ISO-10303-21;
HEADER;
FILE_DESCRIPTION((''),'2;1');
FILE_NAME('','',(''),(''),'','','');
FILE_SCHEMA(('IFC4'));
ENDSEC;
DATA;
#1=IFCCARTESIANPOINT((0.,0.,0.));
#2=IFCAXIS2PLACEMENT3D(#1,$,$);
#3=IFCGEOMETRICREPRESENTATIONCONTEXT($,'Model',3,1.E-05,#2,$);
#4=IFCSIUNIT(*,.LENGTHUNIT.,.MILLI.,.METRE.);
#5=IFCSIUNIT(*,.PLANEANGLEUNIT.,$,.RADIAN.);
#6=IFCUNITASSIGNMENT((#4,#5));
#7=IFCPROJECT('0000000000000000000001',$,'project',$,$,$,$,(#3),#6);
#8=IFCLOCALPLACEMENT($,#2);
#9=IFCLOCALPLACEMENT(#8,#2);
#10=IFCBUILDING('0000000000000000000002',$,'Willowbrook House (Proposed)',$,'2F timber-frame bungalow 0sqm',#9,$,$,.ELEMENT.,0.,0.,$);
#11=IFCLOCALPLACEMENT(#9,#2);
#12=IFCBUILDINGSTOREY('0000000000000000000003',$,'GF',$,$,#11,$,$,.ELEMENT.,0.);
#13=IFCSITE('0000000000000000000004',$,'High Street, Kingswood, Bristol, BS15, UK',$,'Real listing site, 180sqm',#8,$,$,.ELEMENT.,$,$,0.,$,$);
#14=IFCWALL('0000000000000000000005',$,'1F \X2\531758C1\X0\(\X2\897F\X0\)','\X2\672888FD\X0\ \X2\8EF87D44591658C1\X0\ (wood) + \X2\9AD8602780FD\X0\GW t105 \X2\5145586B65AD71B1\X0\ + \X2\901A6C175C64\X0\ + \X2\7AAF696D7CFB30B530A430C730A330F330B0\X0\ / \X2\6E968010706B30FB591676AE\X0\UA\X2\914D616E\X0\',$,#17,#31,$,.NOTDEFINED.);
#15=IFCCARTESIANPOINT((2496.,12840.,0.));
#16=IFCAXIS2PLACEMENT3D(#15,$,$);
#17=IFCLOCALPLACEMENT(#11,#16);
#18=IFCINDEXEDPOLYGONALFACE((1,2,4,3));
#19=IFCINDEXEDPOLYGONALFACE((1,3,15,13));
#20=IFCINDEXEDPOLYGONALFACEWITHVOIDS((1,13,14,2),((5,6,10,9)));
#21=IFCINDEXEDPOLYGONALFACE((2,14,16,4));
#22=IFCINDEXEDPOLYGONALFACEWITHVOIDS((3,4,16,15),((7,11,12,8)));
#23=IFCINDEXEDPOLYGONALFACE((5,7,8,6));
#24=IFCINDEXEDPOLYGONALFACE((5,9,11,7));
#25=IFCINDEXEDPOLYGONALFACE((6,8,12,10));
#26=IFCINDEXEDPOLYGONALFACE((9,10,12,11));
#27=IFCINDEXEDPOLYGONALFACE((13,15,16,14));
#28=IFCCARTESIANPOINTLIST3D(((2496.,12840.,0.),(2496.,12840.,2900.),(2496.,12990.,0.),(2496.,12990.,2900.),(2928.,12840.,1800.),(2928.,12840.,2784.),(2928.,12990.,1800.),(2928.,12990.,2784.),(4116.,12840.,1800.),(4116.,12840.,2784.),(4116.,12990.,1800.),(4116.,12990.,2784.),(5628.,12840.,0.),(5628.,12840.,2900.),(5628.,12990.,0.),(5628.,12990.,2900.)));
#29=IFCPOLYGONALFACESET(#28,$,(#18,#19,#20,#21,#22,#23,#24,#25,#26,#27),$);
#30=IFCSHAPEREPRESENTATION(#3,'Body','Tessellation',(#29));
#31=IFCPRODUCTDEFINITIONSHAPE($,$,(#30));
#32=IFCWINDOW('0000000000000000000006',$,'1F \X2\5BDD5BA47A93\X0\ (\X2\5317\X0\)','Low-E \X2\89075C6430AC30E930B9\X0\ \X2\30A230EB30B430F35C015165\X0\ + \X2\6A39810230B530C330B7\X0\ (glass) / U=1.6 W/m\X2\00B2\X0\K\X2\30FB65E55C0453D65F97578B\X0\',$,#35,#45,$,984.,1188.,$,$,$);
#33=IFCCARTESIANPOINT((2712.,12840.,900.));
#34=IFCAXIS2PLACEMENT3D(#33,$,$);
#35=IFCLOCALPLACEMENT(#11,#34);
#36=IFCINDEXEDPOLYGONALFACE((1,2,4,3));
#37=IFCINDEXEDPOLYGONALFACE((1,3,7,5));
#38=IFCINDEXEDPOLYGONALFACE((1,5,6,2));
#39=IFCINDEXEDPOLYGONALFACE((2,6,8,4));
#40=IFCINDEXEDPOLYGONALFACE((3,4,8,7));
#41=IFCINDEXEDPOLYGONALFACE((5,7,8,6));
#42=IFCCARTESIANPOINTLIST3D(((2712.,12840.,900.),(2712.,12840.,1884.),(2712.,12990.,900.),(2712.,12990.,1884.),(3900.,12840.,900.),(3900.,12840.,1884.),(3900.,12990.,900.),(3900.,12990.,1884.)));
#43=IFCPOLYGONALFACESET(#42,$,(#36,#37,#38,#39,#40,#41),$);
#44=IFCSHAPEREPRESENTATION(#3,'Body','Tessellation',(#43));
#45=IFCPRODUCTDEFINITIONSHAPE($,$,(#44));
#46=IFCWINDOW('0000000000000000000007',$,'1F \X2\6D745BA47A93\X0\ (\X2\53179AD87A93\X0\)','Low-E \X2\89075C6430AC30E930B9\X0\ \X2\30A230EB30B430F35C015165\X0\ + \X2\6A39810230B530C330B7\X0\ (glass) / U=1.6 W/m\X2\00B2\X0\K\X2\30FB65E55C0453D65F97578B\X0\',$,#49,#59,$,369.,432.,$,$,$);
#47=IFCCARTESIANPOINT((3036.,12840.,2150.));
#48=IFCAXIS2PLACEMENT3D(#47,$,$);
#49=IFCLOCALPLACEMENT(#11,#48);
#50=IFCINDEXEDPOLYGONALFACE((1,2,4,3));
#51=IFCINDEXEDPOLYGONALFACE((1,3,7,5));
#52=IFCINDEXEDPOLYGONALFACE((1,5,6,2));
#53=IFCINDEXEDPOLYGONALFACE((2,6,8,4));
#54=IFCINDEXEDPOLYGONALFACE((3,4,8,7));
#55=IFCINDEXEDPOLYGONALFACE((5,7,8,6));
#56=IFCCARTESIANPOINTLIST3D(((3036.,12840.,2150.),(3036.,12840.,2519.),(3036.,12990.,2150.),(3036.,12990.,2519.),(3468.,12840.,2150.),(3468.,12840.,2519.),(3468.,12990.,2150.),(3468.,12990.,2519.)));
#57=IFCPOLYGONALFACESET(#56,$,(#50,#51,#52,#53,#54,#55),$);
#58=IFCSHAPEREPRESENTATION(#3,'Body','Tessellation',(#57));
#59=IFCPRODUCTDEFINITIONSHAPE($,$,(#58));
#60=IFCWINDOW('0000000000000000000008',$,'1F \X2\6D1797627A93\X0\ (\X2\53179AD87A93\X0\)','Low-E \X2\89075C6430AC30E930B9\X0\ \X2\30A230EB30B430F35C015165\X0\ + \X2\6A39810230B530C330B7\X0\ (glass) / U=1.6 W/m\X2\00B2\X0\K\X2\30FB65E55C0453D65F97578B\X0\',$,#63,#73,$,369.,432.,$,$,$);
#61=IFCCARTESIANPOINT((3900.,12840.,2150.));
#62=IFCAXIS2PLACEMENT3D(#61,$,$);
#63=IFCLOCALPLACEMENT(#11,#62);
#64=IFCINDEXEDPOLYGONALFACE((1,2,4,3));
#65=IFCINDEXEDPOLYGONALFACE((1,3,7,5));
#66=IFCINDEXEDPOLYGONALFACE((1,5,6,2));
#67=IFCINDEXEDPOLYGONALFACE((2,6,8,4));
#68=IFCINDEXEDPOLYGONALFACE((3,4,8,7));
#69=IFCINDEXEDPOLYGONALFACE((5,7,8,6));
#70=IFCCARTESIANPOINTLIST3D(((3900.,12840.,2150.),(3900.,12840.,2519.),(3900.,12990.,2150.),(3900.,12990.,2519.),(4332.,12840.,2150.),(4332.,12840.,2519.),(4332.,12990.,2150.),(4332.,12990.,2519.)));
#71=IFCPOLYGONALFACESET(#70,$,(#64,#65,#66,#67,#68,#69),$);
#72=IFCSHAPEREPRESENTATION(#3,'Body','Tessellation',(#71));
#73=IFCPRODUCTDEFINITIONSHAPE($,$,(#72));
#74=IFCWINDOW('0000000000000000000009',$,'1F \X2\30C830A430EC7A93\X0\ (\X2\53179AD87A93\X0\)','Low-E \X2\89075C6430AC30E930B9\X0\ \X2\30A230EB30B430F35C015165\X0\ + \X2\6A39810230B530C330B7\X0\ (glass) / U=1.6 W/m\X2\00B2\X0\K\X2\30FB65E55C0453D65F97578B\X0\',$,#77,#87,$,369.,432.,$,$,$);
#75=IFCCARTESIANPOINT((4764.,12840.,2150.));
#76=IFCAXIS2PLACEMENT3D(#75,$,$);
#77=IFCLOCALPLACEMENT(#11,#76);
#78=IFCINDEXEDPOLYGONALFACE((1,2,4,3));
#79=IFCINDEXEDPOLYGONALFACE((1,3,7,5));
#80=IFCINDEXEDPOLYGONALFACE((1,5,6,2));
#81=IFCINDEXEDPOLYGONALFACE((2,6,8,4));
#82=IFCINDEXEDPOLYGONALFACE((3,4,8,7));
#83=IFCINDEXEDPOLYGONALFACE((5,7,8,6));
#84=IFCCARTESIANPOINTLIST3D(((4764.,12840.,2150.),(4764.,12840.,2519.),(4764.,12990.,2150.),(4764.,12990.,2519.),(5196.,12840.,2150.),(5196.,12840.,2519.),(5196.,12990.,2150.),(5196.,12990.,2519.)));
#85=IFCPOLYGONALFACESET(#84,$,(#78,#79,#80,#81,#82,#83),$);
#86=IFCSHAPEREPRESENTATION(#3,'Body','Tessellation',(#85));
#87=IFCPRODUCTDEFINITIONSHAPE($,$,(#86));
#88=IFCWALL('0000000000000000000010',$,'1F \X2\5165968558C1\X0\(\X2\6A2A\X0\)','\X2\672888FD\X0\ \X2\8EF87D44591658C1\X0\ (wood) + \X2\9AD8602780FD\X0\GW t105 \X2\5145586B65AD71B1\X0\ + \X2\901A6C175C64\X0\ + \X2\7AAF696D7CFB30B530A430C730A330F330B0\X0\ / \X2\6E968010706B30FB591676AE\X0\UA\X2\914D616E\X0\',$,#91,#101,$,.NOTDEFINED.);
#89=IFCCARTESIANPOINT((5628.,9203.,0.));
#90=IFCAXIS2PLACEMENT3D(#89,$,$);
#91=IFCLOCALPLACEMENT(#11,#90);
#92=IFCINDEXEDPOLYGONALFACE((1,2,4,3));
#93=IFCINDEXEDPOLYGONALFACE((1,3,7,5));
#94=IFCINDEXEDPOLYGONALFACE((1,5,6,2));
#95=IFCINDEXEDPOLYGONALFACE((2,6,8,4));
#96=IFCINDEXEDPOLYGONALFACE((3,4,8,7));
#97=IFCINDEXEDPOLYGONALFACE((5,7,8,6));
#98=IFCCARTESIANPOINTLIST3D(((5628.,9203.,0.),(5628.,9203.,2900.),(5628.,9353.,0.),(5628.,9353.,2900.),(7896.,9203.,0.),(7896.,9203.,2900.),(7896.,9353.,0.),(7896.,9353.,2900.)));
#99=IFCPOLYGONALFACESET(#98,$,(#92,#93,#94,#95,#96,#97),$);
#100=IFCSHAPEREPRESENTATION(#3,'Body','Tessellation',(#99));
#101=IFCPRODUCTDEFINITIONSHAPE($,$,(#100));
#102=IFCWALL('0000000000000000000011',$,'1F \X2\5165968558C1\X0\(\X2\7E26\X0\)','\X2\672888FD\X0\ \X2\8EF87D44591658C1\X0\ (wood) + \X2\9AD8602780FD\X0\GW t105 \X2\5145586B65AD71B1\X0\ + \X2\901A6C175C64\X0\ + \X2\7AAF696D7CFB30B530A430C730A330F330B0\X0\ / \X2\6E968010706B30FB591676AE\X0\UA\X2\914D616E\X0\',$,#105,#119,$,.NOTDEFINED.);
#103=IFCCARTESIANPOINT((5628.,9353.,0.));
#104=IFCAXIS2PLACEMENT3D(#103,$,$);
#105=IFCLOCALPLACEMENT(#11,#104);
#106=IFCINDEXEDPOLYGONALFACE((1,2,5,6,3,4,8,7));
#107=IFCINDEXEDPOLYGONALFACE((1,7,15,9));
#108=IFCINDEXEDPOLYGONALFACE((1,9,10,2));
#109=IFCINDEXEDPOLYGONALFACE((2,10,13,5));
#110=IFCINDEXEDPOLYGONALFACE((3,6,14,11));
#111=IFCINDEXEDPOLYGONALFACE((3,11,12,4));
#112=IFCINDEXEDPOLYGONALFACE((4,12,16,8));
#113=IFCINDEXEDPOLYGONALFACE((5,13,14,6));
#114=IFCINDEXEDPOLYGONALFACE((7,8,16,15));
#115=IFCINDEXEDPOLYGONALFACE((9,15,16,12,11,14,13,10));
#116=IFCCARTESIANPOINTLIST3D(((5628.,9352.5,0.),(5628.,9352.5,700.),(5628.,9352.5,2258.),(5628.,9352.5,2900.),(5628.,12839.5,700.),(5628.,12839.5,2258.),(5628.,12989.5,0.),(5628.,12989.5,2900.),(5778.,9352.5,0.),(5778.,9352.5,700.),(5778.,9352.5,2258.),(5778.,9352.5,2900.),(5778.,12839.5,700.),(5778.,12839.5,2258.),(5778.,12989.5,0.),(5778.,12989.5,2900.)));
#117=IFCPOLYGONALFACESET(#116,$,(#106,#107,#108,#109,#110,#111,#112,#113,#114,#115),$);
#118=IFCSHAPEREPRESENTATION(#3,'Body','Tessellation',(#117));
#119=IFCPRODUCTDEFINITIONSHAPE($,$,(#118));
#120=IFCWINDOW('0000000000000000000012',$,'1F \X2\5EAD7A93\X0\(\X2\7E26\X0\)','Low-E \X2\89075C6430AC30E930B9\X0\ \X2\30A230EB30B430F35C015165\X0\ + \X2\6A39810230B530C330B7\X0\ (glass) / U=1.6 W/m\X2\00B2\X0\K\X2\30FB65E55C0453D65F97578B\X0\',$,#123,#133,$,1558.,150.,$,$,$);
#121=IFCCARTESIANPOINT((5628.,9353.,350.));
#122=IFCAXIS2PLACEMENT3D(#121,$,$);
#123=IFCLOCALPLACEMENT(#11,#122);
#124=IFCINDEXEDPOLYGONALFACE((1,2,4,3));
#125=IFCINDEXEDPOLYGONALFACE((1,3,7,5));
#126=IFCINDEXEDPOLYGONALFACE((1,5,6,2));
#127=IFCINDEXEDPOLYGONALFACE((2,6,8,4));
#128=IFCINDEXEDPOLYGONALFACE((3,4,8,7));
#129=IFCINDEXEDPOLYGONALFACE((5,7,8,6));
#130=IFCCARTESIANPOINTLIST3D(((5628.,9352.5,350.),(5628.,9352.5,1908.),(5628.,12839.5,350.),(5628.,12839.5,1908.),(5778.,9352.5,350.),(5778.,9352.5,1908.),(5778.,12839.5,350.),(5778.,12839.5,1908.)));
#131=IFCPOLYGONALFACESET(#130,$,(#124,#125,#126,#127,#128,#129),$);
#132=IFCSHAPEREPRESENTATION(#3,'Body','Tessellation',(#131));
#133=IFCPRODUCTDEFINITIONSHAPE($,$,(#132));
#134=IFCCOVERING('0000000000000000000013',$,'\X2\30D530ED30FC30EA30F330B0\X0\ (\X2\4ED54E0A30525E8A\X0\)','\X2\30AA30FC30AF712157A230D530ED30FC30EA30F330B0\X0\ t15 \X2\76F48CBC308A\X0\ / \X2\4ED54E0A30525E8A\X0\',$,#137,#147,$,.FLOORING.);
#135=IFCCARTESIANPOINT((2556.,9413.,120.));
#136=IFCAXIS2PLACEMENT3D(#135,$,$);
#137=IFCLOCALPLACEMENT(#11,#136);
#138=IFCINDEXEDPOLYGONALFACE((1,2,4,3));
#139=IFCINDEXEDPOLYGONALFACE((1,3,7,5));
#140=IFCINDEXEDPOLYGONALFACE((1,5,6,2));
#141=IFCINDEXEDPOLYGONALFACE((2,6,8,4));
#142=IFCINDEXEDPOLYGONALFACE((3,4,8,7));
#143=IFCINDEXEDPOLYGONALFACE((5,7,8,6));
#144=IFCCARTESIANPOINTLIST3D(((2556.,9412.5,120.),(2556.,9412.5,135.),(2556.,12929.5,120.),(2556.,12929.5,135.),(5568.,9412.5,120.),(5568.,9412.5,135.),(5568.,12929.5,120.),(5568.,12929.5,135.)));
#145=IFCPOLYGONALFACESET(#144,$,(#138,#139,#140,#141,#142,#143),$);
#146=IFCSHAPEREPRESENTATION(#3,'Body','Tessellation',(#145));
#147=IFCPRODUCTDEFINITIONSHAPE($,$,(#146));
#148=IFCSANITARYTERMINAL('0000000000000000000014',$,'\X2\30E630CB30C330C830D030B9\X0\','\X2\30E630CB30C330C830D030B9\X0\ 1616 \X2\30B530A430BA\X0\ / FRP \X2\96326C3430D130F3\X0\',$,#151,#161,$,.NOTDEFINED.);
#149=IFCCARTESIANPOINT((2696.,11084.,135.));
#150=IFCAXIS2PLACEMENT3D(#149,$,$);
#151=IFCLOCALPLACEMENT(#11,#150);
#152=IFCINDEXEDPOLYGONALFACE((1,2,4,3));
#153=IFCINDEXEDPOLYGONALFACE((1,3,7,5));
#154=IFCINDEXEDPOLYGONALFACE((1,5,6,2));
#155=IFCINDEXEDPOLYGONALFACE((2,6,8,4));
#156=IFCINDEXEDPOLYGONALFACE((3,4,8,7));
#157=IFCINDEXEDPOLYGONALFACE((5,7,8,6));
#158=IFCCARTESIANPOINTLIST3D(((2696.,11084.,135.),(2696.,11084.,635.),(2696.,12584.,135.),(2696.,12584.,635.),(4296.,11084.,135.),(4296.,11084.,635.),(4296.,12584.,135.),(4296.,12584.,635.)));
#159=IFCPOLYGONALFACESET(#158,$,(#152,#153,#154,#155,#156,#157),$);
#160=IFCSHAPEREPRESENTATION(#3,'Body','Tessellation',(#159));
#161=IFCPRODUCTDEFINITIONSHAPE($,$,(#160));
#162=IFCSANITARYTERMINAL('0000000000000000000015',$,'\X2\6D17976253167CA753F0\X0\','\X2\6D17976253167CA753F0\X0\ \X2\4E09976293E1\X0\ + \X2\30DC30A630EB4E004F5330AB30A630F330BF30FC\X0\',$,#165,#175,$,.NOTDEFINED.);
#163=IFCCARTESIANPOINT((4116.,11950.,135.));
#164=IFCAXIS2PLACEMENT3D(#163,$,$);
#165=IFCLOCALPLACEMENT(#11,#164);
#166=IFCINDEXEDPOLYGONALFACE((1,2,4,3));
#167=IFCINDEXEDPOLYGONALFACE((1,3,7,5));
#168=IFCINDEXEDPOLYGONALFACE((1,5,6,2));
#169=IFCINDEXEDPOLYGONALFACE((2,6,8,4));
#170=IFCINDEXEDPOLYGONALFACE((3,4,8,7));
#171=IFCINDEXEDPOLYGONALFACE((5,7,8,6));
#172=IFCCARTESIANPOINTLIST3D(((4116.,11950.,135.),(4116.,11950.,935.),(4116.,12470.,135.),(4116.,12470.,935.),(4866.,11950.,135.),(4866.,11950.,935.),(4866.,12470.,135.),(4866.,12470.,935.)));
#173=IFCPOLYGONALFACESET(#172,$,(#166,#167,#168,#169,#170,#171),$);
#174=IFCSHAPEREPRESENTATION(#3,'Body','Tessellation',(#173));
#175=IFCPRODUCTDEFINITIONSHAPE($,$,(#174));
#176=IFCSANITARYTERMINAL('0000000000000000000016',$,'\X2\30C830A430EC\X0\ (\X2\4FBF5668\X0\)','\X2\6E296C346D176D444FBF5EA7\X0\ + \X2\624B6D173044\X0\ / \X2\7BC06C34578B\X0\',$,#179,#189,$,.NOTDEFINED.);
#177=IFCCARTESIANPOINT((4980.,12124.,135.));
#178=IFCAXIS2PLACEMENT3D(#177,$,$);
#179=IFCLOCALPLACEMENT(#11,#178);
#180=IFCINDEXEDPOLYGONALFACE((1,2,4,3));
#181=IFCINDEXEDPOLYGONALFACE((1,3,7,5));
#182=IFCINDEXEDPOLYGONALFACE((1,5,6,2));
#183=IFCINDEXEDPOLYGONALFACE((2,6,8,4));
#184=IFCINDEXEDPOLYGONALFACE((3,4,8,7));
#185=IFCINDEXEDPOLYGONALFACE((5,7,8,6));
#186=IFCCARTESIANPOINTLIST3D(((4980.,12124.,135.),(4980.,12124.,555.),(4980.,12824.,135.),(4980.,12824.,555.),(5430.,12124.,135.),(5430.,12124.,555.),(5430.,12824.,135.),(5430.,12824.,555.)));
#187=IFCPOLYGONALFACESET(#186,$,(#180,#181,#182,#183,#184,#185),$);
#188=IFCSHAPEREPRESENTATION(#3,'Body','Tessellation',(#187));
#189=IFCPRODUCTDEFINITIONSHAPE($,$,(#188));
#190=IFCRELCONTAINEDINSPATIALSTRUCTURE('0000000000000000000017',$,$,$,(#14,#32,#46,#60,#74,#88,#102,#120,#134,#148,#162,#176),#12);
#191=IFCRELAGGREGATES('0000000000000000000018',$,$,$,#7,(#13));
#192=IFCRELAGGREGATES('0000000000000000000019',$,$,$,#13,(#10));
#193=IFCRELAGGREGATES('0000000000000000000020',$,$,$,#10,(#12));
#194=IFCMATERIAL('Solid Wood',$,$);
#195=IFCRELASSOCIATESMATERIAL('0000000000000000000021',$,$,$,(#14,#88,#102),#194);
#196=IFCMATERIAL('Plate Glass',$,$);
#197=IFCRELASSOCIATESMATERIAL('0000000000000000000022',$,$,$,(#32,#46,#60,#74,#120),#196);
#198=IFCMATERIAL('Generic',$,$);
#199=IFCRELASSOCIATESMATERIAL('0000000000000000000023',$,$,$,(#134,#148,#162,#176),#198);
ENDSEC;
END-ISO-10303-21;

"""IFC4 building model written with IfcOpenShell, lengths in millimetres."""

from ifc_helpers import new_model, si_unit, frame, frame_2d, origin, place, context, project, spatial, rectangle, extrude, material, element, fill, save


model = new_model("IFC4")

# Units and contexts
model_context = context("Model", 3, precision=1e-05, world=origin())
ifc_project = project(units=[si_unit("LENGTHUNIT", "METRE", prefix="MILLI"), si_unit("PLANEANGLEUNIT", "RADIAN")], contexts=[model_context])

# Site, building, storey
site_placement = place(None, origin())
site = spatial("IfcSite", under=ifc_project, at=site_placement, Name="High Street, Kingswood, Bristol, BS15, UK", ObjectType="Real listing site, 180sqm", CompositionType="ELEMENT", RefElevation=0.0)
building_placement = place(site_placement, origin())
building = spatial("IfcBuilding", under=site, at=building_placement, Name="Willowbrook House (Proposed)", ObjectType="2F timber-frame bungalow 0sqm", CompositionType="ELEMENT", ElevationOfRefHeight=0.0, ElevationOfTerrain=0.0)
storey_placement = place(building_placement, origin())
storey = spatial("IfcBuildingStorey", under=building, at=storey_placement, Name="GF", CompositionType="ELEMENT", Elevation=0.0)

# Shared definitions
ifc_material_1 = material(Name="Solid Wood")

# Wall, openings, windows
wall_1_placement = place(storey_placement, frame((2496.0, 12840.0, 0.0)))
wall_1 = element("IfcWall", 1, at=wall_1_placement, inside=storey, material=ifc_material_1, Name="1F 北壁(西)", Description="木製 軸組外壁 (wood) + 高性能GW t105 充填断熱 + 通気層 + 窯業系サイディング / 準耐火・外皮UA配慮", PredefinedType="NOTDEFINED", context=model_context, shape_type="SweptSolid", body=[
    extrude(rectangle(XDim=3132.0, YDim=150.0, at=frame_2d((1566.0, 75.0))), frame((2496.0, 12840.0, 0.0)), (0.0, 0.0, 1.0), 2900.0),
])
opening_1_placement = place(storey_placement, frame((2712.0, 12840.0, 900.0)))
opening_1 = element("IfcOpeningElement", 2, at=opening_1_placement, cuts=wall_1, PredefinedType="NOTDEFINED", context=model_context, shape_type="SweptSolid", body=[
    extrude(rectangle(XDim=1188.0, YDim=150.0, at=frame_2d((594.0, 75.0))), frame((2712.0, 12840.0, 900.0)), (0.0, 0.0, 1.0), 984.0),
])
opening_2_placement = place(storey_placement, frame((3036.0, 12840.0, 2150.0)))
opening_2 = element("IfcOpeningElement", 3, at=opening_2_placement, cuts=wall_1, PredefinedType="NOTDEFINED", context=model_context, shape_type="SweptSolid", body=[
    extrude(rectangle(XDim=432.0, YDim=150.0, at=frame_2d((216.0, 75.0))), frame((3036.0, 12840.0, 2150.0)), (0.0, 0.0, 1.0), 369.0),
])
opening_3_placement = place(storey_placement, frame((3900.0, 12840.0, 2150.0)))
opening_3 = element("IfcOpeningElement", 4, at=opening_3_placement, cuts=wall_1, PredefinedType="NOTDEFINED", context=model_context, shape_type="SweptSolid", body=[
    extrude(rectangle(XDim=432.0, YDim=150.0, at=frame_2d((216.0, 75.0))), frame((3900.0, 12840.0, 2150.0)), (0.0, 0.0, 1.0), 369.0),
])
opening_4_placement = place(storey_placement, frame((4764.0, 12840.0, 2150.0)))
opening_4 = element("IfcOpeningElement", 5, at=opening_4_placement, cuts=wall_1, PredefinedType="NOTDEFINED", context=model_context, shape_type="SweptSolid", body=[
    extrude(rectangle(XDim=432.0, YDim=150.0, at=frame_2d((216.0, 75.0))), frame((4764.0, 12840.0, 2150.0)), (0.0, 0.0, 1.0), 369.0),
])
ifc_material_2 = material(Name="Plate Glass")
window_1_placement = place(storey_placement, frame((2712.0, 12840.0, 900.0)))
window_1 = element("IfcWindow", 6, at=window_1_placement, inside=storey, material=ifc_material_2, Name="1F 寝室窓 (北)", Description="Low-E 複層ガラス アルゴン封入 + 樹脂サッシ (glass) / U=1.6 W/m²K・日射取得型", OverallHeight=984.0, OverallWidth=1188.0, context=model_context, shape_type="SweptSolid", body=[
    extrude(rectangle(XDim=1188.0, YDim=150.0, at=frame_2d((594.0, 75.0))), frame((2712.0, 12840.0, 900.0)), (0.0, 0.0, 1.0), 984.0),
])
fill(opening_1, window_1)
window_2_placement = place(storey_placement, frame((3036.0, 12840.0, 2150.0)))
window_2 = element("IfcWindow", 7, at=window_2_placement, inside=storey, material=ifc_material_2, Name="1F 浴室窓 (北高窓)", Description="Low-E 複層ガラス アルゴン封入 + 樹脂サッシ (glass) / U=1.6 W/m²K・日射取得型", OverallHeight=369.0, OverallWidth=432.0, context=model_context, shape_type="SweptSolid", body=[
    extrude(rectangle(XDim=432.0, YDim=150.0, at=frame_2d((216.0, 75.0))), frame((3036.0, 12840.0, 2150.0)), (0.0, 0.0, 1.0), 369.0),
])
fill(opening_2, window_2)
window_3_placement = place(storey_placement, frame((3900.0, 12840.0, 2150.0)))
window_3 = element("IfcWindow", 8, at=window_3_placement, inside=storey, material=ifc_material_2, Name="1F 洗面窓 (北高窓)", Description="Low-E 複層ガラス アルゴン封入 + 樹脂サッシ (glass) / U=1.6 W/m²K・日射取得型", OverallHeight=369.0, OverallWidth=432.0, context=model_context, shape_type="SweptSolid", body=[
    extrude(rectangle(XDim=432.0, YDim=150.0, at=frame_2d((216.0, 75.0))), frame((3900.0, 12840.0, 2150.0)), (0.0, 0.0, 1.0), 369.0),
])
fill(opening_3, window_3)
window_4_placement = place(storey_placement, frame((4764.0, 12840.0, 2150.0)))
window_4 = element("IfcWindow", 9, at=window_4_placement, inside=storey, material=ifc_material_2, Name="1F トイレ窓 (北高窓)", Description="Low-E 複層ガラス アルゴン封入 + 樹脂サッシ (glass) / U=1.6 W/m²K・日射取得型", OverallHeight=369.0, OverallWidth=432.0, context=model_context, shape_type="SweptSolid", body=[
    extrude(rectangle(XDim=432.0, YDim=150.0, at=frame_2d((216.0, 75.0))), frame((4764.0, 12840.0, 2150.0)), (0.0, 0.0, 1.0), 369.0),
])
fill(opening_4, window_4)

# Wall
wall_2_placement = place(storey_placement, frame((5628.0, 9203.0, 0.0)))
element("IfcWall", 10, at=wall_2_placement, inside=storey, material=ifc_material_1, Name="1F 入隅壁(横)", Description="木製 軸組外壁 (wood) + 高性能GW t105 充填断熱 + 通気層 + 窯業系サイディング / 準耐火・外皮UA配慮", PredefinedType="NOTDEFINED", context=model_context, shape_type="SweptSolid", body=[
    extrude(rectangle(XDim=2268.0, YDim=150.0, at=frame_2d((1134.0, 75.0))), frame((5628.0, 9203.0, 0.0)), (0.0, 0.0, 1.0), 2900.0),
])

# Wall, opening, window
wall_3_placement = place(storey_placement, frame((5628.0, 9353.0, 0.0)))
wall_3 = element("IfcWall", 11, at=wall_3_placement, inside=storey, material=ifc_material_1, Name="1F 入隅壁(縦)", Description="木製 軸組外壁 (wood) + 高性能GW t105 充填断熱 + 通気層 + 窯業系サイディング / 準耐火・外皮UA配慮", PredefinedType="NOTDEFINED", context=model_context, shape_type="SweptSolid", body=[
    extrude(rectangle(XDim=150.0, YDim=3637.0, at=frame_2d((75.0, 1818.0))), frame((5628.0, 9353.0, 0.0)), (0.0, 0.0, 1.0), 2900.0),
])
opening_5_placement = place(storey_placement, frame((5628.0, 9353.0, 350.0)))
opening_5 = element("IfcOpeningElement", 12, at=opening_5_placement, cuts=wall_3, PredefinedType="NOTDEFINED", context=model_context, shape_type="SweptSolid", body=[
    extrude(rectangle(XDim=150.0, YDim=3487.0, at=frame_2d((75.0, 1743.0))), frame((5628.0, 9353.0, 350.0)), (0.0, 0.0, 1.0), 1558.0),
])
window_5_placement = place(storey_placement, frame((5628.0, 9353.0, 350.0)))
window_5 = element("IfcWindow", 13, at=window_5_placement, inside=storey, material=ifc_material_2, Name="1F 庭窓(縦)", Description="Low-E 複層ガラス アルゴン封入 + 樹脂サッシ (glass) / U=1.6 W/m²K・日射取得型", OverallHeight=1558.0, OverallWidth=150.0, context=model_context, shape_type="SweptSolid", body=[
    extrude(rectangle(XDim=150.0, YDim=3487.0, at=frame_2d((75.0, 1743.0))), frame((5628.0, 9353.0, 350.0)), (0.0, 0.0, 1.0), 1558.0),
])
fill(opening_5, window_5)

# Covering
ifc_material_3 = material(Name="Generic")
covering_placement = place(storey_placement, frame((2556.0, 9413.0, 120.0)))
element("IfcCovering", 14, at=covering_placement, inside=storey, material=ifc_material_3, Name="フローリング (仕上げ床)", Description="オーク無垢フローリング t15 直貼り / 仕上げ床", PredefinedType="FLOORING", context=model_context, shape_type="SweptSolid", body=[
    extrude(rectangle(XDim=3012.0, YDim=3517.0, at=frame_2d((1506.0, 1758.0))), frame((2556.0, 9413.0, 120.0)), (0.0, 0.0, 1.0), 15.0),
])

# Sanitary terminals
sanitary_terminal_1_placement = place(storey_placement, frame((2696.0, 11084.0, 135.0)))
element("IfcSanitaryTerminal", 15, at=sanitary_terminal_1_placement, inside=storey, material=ifc_material_3, Name="ユニットバス", Description="ユニットバス 1616 サイズ / FRP 防水パン", PredefinedType="NOTDEFINED", context=model_context, shape_type="SweptSolid", body=[
    extrude(rectangle(XDim=1600.0, YDim=1500.0, at=frame_2d((800.0, 750.0))), frame((2696.0, 11084.0, 135.0)), (0.0, 0.0, 1.0), 500.0),
])
sanitary_terminal_2_placement = place(storey_placement, frame((4116.0, 11950.0, 135.0)))
element("IfcSanitaryTerminal", 16, at=sanitary_terminal_2_placement, inside=storey, material=ifc_material_3, Name="洗面化粧台", Description="洗面化粧台 三面鏡 + ボウル一体カウンター", PredefinedType="NOTDEFINED", context=model_context, shape_type="SweptSolid", body=[
    extrude(rectangle(XDim=750.0, YDim=520.0, at=frame_2d((375.0, 260.0))), frame((4116.0, 11950.0, 135.0)), (0.0, 0.0, 1.0), 800.0),
])
sanitary_terminal_3_placement = place(storey_placement, frame((4980.0, 12124.0, 135.0)))
element("IfcSanitaryTerminal", 17, at=sanitary_terminal_3_placement, inside=storey, material=ifc_material_3, Name="トイレ (便器)", Description="温水洗浄便座 + 手洗い / 節水型", PredefinedType="NOTDEFINED", context=model_context, shape_type="SweptSolid", body=[
    extrude(rectangle(XDim=450.0, YDim=700.0, at=frame_2d((225.0, 350.0))), frame((4980.0, 12124.0, 135.0)), (0.0, 0.0, 1.0), 420.0),
])

save(model, "model.ifc")
